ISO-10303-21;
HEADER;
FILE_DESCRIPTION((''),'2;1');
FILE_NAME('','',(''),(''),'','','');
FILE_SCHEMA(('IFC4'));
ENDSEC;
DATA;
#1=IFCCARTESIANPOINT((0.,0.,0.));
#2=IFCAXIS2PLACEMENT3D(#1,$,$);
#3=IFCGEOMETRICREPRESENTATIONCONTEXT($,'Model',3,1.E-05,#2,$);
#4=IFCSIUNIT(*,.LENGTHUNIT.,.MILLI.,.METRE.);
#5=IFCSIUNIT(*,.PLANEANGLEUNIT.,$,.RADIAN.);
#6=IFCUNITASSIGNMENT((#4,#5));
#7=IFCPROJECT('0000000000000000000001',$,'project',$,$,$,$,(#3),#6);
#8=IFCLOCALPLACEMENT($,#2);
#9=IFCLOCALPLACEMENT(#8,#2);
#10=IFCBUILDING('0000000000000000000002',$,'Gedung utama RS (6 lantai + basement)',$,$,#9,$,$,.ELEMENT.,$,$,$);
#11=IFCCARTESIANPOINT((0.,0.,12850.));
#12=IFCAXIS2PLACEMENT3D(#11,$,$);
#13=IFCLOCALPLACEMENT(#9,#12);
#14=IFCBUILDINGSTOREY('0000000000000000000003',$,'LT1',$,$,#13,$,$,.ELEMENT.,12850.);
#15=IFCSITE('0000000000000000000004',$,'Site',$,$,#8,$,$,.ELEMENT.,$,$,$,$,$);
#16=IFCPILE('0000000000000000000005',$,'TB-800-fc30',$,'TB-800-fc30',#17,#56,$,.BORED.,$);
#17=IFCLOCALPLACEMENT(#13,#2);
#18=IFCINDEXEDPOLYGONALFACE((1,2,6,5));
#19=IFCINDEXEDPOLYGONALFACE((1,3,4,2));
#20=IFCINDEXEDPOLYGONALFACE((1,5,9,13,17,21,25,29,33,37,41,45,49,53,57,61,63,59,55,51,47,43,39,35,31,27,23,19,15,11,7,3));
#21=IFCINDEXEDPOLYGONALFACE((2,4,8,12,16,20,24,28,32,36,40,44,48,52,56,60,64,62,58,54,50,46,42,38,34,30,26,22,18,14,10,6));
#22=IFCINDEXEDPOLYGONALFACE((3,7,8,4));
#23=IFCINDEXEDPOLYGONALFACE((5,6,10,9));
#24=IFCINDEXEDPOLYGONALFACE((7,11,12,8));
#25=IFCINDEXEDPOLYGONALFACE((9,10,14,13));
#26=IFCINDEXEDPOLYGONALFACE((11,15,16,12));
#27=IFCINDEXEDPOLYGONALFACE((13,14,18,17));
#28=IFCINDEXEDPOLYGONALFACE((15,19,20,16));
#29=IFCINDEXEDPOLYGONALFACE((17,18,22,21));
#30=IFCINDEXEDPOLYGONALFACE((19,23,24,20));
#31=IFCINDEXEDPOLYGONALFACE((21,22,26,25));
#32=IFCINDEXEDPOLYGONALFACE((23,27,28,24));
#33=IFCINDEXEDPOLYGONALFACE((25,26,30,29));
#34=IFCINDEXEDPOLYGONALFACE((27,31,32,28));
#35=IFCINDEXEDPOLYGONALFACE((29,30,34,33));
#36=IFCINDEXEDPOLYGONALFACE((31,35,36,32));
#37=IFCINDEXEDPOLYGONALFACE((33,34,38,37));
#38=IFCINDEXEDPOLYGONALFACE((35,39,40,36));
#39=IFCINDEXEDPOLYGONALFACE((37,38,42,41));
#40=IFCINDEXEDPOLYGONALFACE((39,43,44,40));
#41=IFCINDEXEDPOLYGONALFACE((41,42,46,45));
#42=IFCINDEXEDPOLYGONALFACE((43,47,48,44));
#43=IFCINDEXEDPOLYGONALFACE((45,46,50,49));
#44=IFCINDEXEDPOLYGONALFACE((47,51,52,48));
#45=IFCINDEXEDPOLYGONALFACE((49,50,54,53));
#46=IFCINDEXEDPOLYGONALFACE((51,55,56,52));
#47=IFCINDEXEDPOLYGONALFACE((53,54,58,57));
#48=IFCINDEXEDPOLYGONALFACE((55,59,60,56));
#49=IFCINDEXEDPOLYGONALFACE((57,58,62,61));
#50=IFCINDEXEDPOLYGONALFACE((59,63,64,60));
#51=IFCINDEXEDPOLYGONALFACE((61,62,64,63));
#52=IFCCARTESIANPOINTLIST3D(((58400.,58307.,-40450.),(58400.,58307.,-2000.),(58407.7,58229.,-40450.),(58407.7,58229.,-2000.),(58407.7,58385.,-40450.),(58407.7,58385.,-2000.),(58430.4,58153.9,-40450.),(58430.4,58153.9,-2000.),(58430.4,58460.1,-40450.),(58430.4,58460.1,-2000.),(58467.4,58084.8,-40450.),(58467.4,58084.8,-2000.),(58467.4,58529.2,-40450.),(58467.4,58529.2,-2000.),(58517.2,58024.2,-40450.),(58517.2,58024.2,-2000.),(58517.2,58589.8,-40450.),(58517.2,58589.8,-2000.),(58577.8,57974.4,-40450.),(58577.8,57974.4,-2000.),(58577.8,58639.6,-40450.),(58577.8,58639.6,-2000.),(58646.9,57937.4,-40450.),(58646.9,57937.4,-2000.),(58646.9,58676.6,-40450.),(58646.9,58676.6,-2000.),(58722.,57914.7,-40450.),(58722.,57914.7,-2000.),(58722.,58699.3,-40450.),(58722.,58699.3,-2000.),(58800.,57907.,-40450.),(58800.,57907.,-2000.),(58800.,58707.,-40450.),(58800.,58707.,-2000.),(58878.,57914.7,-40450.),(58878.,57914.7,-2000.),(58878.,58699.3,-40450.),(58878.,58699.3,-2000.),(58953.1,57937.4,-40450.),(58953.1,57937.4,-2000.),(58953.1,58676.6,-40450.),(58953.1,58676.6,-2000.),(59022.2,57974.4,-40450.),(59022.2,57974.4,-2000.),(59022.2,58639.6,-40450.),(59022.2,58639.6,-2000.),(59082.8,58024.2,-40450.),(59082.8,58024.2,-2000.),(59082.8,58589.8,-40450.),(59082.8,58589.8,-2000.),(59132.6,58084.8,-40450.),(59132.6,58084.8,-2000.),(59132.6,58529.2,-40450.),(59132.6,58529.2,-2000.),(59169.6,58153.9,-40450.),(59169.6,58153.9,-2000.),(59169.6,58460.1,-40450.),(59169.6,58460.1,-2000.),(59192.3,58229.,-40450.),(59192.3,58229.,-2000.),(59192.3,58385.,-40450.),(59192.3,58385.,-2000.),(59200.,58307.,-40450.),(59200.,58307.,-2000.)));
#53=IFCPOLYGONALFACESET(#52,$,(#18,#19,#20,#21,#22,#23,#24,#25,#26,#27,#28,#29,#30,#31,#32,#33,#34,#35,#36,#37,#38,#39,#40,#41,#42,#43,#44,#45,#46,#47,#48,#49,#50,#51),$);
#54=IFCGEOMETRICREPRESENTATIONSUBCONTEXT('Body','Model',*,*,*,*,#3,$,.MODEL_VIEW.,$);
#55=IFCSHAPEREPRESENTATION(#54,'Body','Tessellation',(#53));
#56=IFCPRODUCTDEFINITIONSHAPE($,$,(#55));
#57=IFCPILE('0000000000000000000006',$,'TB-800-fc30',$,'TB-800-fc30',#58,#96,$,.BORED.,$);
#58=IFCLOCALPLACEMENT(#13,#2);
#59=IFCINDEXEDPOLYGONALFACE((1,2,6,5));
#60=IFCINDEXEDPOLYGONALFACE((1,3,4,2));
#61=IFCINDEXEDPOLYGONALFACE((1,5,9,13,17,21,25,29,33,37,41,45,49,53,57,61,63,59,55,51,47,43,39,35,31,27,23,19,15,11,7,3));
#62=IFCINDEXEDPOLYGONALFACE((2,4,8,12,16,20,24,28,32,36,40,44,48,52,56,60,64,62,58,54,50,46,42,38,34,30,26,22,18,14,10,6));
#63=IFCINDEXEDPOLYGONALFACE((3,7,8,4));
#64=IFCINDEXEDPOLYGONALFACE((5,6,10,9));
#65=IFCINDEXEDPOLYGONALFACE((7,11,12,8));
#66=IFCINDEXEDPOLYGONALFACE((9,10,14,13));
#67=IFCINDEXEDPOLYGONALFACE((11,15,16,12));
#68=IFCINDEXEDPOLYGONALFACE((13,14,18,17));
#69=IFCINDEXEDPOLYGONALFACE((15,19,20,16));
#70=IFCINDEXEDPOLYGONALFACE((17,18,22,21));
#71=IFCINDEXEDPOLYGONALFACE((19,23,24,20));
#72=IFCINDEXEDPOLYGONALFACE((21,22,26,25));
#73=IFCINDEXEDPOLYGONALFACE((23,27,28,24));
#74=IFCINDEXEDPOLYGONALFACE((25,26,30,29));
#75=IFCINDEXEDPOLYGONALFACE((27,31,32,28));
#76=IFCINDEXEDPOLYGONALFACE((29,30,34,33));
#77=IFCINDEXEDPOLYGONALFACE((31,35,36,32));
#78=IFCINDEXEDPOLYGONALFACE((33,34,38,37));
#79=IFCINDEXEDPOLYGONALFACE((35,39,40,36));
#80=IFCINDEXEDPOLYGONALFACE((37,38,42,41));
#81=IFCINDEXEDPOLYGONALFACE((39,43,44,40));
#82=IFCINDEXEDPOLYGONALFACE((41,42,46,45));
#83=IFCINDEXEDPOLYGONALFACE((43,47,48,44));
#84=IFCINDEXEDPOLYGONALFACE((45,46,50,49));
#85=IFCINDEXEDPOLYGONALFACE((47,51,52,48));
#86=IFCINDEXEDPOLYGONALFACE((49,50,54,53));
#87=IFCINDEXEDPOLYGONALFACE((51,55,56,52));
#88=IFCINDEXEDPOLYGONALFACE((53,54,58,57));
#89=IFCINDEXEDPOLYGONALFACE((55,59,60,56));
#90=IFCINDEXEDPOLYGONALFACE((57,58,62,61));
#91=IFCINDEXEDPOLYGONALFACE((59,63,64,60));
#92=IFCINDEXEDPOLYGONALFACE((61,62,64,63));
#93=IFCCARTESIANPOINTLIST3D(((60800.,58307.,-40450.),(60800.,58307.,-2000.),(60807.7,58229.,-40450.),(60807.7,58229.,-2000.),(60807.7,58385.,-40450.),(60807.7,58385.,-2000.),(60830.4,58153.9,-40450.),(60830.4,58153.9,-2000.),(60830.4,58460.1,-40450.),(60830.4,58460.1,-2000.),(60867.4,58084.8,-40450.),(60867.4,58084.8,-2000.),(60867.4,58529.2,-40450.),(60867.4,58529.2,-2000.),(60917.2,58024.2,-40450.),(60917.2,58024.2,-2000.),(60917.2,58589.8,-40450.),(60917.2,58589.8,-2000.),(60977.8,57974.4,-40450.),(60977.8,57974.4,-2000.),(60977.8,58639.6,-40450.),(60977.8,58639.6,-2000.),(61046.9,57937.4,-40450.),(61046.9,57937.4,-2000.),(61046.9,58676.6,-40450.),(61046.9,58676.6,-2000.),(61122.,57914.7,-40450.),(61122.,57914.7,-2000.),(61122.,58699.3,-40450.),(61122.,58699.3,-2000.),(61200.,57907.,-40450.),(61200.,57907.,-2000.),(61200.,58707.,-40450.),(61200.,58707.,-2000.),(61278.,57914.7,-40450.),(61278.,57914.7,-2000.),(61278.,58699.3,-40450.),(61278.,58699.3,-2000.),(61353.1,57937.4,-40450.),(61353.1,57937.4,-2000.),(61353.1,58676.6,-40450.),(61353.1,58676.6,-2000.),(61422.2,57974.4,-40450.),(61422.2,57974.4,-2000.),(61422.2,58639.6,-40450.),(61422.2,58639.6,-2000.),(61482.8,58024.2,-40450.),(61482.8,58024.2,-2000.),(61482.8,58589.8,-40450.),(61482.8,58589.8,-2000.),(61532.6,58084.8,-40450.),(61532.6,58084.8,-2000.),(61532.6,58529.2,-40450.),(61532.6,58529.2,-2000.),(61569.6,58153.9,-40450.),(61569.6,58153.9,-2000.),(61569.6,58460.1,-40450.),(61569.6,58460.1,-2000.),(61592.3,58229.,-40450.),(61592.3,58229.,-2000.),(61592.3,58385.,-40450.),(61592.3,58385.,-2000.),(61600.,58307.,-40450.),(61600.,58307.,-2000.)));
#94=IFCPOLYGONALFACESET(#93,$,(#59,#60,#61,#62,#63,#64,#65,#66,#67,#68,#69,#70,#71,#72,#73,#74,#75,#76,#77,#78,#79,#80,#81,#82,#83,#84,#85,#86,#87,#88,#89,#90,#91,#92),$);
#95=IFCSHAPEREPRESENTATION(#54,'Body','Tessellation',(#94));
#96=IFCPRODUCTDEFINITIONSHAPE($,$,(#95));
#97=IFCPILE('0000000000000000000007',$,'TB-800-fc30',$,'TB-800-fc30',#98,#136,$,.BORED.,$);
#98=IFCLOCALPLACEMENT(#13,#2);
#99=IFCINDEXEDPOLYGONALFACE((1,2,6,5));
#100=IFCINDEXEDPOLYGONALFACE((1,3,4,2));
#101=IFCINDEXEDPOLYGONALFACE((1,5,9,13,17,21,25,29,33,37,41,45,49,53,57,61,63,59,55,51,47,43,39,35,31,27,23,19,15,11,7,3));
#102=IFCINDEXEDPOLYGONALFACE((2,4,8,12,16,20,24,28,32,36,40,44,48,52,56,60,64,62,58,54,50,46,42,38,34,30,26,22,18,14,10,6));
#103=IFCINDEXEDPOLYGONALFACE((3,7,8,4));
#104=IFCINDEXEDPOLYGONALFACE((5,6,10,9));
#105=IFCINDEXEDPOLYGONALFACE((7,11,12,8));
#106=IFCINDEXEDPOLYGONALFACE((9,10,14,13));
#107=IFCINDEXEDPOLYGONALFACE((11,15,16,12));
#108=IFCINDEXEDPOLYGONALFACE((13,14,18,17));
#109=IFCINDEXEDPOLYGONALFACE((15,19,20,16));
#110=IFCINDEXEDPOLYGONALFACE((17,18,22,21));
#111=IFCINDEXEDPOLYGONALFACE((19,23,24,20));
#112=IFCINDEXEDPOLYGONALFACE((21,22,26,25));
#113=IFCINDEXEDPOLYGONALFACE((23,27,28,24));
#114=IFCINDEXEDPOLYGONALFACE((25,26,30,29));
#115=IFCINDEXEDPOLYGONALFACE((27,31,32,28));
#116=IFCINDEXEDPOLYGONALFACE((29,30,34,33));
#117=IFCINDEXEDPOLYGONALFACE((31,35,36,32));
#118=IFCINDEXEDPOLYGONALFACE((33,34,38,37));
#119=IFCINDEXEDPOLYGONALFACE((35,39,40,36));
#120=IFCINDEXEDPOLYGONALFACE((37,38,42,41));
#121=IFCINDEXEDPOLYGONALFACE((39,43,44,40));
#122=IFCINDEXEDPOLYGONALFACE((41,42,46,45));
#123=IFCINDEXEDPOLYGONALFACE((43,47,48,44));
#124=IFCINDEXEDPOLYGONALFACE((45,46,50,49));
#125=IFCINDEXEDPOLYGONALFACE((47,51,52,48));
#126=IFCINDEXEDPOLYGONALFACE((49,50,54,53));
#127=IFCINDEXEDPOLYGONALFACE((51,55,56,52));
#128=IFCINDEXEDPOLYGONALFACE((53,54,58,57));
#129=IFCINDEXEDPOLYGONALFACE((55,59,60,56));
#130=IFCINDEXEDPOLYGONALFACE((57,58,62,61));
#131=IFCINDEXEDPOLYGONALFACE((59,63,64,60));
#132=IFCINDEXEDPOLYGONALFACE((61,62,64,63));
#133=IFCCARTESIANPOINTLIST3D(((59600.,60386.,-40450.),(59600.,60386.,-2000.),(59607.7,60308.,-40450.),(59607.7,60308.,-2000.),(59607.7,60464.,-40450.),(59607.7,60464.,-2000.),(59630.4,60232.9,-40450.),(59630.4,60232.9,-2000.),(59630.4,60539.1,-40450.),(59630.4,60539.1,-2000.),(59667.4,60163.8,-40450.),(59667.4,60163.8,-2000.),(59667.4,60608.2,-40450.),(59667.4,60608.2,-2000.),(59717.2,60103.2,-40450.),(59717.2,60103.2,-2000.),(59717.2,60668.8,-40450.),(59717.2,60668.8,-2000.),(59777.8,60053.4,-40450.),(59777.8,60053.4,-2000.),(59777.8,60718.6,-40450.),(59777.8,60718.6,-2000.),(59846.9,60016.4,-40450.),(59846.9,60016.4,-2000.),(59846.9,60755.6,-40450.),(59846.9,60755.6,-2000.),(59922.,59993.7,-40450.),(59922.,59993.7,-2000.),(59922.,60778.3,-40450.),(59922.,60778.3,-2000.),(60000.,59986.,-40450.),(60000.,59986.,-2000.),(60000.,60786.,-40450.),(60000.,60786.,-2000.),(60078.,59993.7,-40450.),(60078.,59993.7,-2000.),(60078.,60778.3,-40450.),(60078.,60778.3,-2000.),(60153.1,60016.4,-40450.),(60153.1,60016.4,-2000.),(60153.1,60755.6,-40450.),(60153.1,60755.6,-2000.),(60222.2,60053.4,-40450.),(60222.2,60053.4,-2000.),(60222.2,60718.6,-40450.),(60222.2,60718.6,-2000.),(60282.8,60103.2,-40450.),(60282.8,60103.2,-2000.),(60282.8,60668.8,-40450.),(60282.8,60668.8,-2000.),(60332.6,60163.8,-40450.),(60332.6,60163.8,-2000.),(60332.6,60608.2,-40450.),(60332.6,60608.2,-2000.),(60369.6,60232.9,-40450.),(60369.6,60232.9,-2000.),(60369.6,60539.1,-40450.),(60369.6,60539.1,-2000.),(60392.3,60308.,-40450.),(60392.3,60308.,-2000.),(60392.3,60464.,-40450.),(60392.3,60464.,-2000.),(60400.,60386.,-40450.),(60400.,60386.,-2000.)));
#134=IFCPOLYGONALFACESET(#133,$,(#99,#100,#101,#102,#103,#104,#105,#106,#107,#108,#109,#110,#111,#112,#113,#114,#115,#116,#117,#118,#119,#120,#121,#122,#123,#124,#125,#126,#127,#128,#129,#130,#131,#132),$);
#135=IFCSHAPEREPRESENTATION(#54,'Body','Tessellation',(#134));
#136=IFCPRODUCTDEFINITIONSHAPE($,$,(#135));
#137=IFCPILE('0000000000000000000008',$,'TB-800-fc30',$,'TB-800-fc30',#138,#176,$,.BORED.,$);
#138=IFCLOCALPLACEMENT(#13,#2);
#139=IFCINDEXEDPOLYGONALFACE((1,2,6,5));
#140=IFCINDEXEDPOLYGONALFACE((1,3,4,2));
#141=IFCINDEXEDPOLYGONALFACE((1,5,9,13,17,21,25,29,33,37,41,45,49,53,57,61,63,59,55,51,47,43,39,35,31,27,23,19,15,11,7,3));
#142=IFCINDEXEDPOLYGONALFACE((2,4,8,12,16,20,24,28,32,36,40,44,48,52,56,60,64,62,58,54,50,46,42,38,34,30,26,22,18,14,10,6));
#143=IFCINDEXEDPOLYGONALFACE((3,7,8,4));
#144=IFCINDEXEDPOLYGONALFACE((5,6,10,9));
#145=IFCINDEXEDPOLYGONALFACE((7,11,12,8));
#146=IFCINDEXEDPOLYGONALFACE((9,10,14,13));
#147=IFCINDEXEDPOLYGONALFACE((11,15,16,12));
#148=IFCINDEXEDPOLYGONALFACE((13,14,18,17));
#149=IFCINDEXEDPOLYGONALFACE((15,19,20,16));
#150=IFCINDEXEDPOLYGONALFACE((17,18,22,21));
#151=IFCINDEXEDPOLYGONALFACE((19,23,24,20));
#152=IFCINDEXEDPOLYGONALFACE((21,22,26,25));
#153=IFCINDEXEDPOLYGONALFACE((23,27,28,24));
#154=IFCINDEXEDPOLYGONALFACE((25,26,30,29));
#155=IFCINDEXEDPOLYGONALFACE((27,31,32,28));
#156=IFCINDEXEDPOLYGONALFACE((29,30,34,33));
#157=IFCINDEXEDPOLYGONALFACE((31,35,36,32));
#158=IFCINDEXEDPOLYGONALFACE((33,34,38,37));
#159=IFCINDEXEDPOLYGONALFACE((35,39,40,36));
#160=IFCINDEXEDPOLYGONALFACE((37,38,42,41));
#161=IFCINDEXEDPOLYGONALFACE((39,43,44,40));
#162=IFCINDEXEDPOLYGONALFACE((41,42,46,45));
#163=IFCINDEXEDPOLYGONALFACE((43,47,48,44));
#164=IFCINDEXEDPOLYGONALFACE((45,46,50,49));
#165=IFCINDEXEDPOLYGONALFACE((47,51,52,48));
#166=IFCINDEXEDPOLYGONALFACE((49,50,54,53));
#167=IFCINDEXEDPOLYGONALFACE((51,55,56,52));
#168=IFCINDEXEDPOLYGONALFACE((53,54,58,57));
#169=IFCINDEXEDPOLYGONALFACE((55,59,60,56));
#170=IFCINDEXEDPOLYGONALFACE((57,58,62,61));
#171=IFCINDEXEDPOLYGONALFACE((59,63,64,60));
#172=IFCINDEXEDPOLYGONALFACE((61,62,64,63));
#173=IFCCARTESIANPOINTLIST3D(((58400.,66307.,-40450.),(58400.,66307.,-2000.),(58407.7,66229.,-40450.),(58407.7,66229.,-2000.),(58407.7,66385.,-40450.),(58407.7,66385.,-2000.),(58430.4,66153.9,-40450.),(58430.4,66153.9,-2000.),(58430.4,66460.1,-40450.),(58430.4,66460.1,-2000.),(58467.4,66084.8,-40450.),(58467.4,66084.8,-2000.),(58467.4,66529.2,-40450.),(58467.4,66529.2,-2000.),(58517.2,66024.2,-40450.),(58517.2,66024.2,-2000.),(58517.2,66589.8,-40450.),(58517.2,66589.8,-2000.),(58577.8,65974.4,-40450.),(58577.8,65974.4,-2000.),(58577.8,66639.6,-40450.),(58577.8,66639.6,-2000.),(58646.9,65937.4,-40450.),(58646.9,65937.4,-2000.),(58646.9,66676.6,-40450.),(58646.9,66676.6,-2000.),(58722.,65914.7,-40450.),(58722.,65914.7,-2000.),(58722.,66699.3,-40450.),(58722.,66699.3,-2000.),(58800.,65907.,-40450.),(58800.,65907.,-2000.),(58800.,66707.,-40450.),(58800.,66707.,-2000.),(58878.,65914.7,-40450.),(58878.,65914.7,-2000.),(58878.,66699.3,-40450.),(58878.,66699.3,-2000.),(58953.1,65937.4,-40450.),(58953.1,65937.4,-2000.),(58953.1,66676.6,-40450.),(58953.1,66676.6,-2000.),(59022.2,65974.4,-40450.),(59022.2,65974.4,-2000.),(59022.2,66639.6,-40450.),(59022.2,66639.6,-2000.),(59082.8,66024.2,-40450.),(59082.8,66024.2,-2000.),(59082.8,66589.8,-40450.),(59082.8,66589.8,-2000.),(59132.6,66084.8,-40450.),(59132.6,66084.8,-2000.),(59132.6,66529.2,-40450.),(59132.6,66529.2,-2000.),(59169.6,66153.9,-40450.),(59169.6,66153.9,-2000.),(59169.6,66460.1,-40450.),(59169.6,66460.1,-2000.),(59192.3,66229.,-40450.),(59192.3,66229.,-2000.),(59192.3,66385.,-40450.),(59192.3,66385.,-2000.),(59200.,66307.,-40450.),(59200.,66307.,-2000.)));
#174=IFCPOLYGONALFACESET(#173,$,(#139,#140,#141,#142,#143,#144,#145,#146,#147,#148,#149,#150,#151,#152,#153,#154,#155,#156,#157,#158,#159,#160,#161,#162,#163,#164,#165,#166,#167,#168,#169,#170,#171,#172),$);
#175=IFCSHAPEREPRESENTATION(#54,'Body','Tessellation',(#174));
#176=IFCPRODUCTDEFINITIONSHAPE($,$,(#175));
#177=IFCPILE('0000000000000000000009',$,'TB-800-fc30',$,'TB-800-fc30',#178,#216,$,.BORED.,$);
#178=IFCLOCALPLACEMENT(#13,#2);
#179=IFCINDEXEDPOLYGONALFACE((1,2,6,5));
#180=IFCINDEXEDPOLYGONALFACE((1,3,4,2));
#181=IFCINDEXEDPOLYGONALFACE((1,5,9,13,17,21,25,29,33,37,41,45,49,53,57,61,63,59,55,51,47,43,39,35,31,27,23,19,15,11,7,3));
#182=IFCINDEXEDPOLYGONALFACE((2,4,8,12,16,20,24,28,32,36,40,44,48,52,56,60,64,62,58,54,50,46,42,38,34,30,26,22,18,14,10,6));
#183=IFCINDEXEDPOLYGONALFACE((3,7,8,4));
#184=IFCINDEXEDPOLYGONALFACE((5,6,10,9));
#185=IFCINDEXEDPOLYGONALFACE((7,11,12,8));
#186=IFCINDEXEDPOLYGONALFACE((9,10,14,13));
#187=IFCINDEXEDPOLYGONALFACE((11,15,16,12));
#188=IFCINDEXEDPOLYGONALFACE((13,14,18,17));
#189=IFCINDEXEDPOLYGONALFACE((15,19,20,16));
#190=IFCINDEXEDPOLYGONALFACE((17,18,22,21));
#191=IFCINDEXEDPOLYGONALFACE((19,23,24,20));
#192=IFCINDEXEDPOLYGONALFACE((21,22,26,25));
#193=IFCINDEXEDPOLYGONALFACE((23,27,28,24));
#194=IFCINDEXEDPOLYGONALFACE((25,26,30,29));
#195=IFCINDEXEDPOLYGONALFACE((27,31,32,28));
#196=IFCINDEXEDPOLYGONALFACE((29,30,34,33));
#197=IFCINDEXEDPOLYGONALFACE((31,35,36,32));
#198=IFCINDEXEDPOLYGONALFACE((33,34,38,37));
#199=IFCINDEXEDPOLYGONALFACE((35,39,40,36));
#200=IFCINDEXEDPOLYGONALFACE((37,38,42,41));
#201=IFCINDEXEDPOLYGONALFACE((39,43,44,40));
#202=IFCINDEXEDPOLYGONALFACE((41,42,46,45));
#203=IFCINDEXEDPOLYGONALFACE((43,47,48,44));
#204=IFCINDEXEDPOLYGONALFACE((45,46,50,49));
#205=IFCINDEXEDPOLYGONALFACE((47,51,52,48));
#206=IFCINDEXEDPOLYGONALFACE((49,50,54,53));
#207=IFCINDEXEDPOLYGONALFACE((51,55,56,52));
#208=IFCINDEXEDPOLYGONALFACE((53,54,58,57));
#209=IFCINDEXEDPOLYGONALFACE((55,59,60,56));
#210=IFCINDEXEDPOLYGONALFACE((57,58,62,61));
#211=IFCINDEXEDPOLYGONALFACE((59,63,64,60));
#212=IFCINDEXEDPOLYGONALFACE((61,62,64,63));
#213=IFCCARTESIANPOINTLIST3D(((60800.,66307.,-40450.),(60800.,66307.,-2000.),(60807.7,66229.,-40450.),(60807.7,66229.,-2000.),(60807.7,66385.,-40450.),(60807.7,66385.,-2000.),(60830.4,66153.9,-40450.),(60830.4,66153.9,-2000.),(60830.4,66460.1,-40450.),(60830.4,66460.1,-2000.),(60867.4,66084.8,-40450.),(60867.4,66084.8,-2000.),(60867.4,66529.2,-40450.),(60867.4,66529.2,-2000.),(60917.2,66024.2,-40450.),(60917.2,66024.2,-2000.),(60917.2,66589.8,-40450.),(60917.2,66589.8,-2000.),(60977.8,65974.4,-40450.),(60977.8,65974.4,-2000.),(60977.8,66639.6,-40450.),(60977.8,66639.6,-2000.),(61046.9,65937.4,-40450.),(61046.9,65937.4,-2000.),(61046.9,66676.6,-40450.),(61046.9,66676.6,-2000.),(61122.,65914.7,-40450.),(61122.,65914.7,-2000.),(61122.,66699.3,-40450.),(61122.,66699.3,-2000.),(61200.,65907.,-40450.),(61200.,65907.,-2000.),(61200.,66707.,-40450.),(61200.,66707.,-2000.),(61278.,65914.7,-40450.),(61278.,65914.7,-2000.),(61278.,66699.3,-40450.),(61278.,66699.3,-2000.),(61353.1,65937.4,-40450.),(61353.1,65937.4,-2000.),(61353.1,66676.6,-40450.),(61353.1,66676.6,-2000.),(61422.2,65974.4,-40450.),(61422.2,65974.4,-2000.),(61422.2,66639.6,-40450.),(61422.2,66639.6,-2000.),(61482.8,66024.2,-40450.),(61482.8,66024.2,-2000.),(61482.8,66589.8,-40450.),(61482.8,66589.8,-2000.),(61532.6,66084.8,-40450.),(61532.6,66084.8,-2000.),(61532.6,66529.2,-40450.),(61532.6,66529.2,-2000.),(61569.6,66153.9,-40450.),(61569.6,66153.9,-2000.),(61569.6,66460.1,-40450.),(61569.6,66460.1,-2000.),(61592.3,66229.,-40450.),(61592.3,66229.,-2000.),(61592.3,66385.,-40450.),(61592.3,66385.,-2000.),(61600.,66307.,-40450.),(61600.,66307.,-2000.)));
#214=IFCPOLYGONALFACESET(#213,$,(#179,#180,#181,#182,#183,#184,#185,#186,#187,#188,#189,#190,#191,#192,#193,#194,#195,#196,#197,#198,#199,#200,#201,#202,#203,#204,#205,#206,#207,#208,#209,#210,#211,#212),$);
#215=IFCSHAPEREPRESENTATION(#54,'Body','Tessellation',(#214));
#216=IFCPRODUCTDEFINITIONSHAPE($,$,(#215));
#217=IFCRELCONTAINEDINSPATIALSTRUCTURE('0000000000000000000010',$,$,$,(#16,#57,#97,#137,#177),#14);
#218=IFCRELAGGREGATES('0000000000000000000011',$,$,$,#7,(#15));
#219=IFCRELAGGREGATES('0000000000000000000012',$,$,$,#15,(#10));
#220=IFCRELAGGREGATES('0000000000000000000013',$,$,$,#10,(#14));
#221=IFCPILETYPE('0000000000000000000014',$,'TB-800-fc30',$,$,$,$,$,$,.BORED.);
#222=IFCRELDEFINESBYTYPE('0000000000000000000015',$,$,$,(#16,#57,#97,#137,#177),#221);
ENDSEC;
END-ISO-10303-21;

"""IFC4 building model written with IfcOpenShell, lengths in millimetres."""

from ifc_helpers import new_model, si_unit, frame, origin, origin_2d, place, context, subcontext, project, spatial, circle, extrude, material_profile, profile_set, profile_usage, type_object, element, save


model = new_model("IFC4")

# Units and contexts
model_context = context("Model", 3, precision=1e-05, world=origin())
body_context = subcontext(model_context, "Body", "Model", "MODEL_VIEW")
ifc_project = project(units=[si_unit("LENGTHUNIT", "METRE", prefix="MILLI"), si_unit("PLANEANGLEUNIT", "RADIAN")], contexts=[model_context])

# Site, building, storey
site_placement = place(None, origin())
site = spatial("IfcSite", under=ifc_project, at=site_placement, Name="Site", CompositionType="ELEMENT")
building_placement = place(site_placement, origin())
building = spatial("IfcBuilding", under=site, at=building_placement, Name="Gedung utama RS (6 lantai + basement)", CompositionType="ELEMENT")
storey_placement = place(building_placement, frame((0.0, 0.0, 12850.0)))
storey = spatial("IfcBuildingStorey", under=building, at=storey_placement, Name="LT1", CompositionType="ELEMENT", Elevation=12850.0)

# Piles
ifc_material_profile = material_profile(None, circle(Radius=400.0, at=origin_2d()), Name="TB-800-fc30")
ifc_profile_set = profile_set([ifc_material_profile], Name="TB-800-fc30")
ifc_profile_usage = profile_usage(ifc_profile_set, cardinal=5)
pile_type = type_object("IfcPileType", Name="TB-800-fc30", PredefinedType="BORED", material=ifc_profile_set)
for number, where, z_axis, x_axis, name in (
    (1, (58800.0, 58307.0, -40450.0), (0.0, 0.0, 1.0), (1.0, 0.0, 0.0), "TB-800-fc30"),
    (2, (61200.0, 58307.0, -40450.0), (0.0, 0.0, 1.0), (1.0, 0.0, 0.0), "TB-800-fc30"),
    (3, (60000.0, 60386.0, -40450.0), (0.0, 0.0, 1.0), (1.0, 0.0, 0.0), "TB-800-fc30"),
    (4, (58800.0, 66307.0, -40450.0), (0.0, 0.0, 1.0), (1.0, 0.0, 0.0), "TB-800-fc30"),
    (5, (61200.0, 66307.0, -40450.0), (0.0, 0.0, 1.0), (1.0, 0.0, 0.0), "TB-800-fc30"),
):
    element("IfcPile", number, at=place(storey_placement, frame(where, z_axis=z_axis, x_axis=x_axis)), inside=storey, type_object=pile_type, material=ifc_profile_usage, Name=name, ObjectType="TB-800-fc30", PredefinedType="BORED", context=body_context, shape_type="SweptSolid", body=[
        extrude(circle(Radius=400.0, at=origin_2d()), origin(), (0.0, 0.0, 1.0), 38450.0),
    ])

save(model, "model.ifc")
